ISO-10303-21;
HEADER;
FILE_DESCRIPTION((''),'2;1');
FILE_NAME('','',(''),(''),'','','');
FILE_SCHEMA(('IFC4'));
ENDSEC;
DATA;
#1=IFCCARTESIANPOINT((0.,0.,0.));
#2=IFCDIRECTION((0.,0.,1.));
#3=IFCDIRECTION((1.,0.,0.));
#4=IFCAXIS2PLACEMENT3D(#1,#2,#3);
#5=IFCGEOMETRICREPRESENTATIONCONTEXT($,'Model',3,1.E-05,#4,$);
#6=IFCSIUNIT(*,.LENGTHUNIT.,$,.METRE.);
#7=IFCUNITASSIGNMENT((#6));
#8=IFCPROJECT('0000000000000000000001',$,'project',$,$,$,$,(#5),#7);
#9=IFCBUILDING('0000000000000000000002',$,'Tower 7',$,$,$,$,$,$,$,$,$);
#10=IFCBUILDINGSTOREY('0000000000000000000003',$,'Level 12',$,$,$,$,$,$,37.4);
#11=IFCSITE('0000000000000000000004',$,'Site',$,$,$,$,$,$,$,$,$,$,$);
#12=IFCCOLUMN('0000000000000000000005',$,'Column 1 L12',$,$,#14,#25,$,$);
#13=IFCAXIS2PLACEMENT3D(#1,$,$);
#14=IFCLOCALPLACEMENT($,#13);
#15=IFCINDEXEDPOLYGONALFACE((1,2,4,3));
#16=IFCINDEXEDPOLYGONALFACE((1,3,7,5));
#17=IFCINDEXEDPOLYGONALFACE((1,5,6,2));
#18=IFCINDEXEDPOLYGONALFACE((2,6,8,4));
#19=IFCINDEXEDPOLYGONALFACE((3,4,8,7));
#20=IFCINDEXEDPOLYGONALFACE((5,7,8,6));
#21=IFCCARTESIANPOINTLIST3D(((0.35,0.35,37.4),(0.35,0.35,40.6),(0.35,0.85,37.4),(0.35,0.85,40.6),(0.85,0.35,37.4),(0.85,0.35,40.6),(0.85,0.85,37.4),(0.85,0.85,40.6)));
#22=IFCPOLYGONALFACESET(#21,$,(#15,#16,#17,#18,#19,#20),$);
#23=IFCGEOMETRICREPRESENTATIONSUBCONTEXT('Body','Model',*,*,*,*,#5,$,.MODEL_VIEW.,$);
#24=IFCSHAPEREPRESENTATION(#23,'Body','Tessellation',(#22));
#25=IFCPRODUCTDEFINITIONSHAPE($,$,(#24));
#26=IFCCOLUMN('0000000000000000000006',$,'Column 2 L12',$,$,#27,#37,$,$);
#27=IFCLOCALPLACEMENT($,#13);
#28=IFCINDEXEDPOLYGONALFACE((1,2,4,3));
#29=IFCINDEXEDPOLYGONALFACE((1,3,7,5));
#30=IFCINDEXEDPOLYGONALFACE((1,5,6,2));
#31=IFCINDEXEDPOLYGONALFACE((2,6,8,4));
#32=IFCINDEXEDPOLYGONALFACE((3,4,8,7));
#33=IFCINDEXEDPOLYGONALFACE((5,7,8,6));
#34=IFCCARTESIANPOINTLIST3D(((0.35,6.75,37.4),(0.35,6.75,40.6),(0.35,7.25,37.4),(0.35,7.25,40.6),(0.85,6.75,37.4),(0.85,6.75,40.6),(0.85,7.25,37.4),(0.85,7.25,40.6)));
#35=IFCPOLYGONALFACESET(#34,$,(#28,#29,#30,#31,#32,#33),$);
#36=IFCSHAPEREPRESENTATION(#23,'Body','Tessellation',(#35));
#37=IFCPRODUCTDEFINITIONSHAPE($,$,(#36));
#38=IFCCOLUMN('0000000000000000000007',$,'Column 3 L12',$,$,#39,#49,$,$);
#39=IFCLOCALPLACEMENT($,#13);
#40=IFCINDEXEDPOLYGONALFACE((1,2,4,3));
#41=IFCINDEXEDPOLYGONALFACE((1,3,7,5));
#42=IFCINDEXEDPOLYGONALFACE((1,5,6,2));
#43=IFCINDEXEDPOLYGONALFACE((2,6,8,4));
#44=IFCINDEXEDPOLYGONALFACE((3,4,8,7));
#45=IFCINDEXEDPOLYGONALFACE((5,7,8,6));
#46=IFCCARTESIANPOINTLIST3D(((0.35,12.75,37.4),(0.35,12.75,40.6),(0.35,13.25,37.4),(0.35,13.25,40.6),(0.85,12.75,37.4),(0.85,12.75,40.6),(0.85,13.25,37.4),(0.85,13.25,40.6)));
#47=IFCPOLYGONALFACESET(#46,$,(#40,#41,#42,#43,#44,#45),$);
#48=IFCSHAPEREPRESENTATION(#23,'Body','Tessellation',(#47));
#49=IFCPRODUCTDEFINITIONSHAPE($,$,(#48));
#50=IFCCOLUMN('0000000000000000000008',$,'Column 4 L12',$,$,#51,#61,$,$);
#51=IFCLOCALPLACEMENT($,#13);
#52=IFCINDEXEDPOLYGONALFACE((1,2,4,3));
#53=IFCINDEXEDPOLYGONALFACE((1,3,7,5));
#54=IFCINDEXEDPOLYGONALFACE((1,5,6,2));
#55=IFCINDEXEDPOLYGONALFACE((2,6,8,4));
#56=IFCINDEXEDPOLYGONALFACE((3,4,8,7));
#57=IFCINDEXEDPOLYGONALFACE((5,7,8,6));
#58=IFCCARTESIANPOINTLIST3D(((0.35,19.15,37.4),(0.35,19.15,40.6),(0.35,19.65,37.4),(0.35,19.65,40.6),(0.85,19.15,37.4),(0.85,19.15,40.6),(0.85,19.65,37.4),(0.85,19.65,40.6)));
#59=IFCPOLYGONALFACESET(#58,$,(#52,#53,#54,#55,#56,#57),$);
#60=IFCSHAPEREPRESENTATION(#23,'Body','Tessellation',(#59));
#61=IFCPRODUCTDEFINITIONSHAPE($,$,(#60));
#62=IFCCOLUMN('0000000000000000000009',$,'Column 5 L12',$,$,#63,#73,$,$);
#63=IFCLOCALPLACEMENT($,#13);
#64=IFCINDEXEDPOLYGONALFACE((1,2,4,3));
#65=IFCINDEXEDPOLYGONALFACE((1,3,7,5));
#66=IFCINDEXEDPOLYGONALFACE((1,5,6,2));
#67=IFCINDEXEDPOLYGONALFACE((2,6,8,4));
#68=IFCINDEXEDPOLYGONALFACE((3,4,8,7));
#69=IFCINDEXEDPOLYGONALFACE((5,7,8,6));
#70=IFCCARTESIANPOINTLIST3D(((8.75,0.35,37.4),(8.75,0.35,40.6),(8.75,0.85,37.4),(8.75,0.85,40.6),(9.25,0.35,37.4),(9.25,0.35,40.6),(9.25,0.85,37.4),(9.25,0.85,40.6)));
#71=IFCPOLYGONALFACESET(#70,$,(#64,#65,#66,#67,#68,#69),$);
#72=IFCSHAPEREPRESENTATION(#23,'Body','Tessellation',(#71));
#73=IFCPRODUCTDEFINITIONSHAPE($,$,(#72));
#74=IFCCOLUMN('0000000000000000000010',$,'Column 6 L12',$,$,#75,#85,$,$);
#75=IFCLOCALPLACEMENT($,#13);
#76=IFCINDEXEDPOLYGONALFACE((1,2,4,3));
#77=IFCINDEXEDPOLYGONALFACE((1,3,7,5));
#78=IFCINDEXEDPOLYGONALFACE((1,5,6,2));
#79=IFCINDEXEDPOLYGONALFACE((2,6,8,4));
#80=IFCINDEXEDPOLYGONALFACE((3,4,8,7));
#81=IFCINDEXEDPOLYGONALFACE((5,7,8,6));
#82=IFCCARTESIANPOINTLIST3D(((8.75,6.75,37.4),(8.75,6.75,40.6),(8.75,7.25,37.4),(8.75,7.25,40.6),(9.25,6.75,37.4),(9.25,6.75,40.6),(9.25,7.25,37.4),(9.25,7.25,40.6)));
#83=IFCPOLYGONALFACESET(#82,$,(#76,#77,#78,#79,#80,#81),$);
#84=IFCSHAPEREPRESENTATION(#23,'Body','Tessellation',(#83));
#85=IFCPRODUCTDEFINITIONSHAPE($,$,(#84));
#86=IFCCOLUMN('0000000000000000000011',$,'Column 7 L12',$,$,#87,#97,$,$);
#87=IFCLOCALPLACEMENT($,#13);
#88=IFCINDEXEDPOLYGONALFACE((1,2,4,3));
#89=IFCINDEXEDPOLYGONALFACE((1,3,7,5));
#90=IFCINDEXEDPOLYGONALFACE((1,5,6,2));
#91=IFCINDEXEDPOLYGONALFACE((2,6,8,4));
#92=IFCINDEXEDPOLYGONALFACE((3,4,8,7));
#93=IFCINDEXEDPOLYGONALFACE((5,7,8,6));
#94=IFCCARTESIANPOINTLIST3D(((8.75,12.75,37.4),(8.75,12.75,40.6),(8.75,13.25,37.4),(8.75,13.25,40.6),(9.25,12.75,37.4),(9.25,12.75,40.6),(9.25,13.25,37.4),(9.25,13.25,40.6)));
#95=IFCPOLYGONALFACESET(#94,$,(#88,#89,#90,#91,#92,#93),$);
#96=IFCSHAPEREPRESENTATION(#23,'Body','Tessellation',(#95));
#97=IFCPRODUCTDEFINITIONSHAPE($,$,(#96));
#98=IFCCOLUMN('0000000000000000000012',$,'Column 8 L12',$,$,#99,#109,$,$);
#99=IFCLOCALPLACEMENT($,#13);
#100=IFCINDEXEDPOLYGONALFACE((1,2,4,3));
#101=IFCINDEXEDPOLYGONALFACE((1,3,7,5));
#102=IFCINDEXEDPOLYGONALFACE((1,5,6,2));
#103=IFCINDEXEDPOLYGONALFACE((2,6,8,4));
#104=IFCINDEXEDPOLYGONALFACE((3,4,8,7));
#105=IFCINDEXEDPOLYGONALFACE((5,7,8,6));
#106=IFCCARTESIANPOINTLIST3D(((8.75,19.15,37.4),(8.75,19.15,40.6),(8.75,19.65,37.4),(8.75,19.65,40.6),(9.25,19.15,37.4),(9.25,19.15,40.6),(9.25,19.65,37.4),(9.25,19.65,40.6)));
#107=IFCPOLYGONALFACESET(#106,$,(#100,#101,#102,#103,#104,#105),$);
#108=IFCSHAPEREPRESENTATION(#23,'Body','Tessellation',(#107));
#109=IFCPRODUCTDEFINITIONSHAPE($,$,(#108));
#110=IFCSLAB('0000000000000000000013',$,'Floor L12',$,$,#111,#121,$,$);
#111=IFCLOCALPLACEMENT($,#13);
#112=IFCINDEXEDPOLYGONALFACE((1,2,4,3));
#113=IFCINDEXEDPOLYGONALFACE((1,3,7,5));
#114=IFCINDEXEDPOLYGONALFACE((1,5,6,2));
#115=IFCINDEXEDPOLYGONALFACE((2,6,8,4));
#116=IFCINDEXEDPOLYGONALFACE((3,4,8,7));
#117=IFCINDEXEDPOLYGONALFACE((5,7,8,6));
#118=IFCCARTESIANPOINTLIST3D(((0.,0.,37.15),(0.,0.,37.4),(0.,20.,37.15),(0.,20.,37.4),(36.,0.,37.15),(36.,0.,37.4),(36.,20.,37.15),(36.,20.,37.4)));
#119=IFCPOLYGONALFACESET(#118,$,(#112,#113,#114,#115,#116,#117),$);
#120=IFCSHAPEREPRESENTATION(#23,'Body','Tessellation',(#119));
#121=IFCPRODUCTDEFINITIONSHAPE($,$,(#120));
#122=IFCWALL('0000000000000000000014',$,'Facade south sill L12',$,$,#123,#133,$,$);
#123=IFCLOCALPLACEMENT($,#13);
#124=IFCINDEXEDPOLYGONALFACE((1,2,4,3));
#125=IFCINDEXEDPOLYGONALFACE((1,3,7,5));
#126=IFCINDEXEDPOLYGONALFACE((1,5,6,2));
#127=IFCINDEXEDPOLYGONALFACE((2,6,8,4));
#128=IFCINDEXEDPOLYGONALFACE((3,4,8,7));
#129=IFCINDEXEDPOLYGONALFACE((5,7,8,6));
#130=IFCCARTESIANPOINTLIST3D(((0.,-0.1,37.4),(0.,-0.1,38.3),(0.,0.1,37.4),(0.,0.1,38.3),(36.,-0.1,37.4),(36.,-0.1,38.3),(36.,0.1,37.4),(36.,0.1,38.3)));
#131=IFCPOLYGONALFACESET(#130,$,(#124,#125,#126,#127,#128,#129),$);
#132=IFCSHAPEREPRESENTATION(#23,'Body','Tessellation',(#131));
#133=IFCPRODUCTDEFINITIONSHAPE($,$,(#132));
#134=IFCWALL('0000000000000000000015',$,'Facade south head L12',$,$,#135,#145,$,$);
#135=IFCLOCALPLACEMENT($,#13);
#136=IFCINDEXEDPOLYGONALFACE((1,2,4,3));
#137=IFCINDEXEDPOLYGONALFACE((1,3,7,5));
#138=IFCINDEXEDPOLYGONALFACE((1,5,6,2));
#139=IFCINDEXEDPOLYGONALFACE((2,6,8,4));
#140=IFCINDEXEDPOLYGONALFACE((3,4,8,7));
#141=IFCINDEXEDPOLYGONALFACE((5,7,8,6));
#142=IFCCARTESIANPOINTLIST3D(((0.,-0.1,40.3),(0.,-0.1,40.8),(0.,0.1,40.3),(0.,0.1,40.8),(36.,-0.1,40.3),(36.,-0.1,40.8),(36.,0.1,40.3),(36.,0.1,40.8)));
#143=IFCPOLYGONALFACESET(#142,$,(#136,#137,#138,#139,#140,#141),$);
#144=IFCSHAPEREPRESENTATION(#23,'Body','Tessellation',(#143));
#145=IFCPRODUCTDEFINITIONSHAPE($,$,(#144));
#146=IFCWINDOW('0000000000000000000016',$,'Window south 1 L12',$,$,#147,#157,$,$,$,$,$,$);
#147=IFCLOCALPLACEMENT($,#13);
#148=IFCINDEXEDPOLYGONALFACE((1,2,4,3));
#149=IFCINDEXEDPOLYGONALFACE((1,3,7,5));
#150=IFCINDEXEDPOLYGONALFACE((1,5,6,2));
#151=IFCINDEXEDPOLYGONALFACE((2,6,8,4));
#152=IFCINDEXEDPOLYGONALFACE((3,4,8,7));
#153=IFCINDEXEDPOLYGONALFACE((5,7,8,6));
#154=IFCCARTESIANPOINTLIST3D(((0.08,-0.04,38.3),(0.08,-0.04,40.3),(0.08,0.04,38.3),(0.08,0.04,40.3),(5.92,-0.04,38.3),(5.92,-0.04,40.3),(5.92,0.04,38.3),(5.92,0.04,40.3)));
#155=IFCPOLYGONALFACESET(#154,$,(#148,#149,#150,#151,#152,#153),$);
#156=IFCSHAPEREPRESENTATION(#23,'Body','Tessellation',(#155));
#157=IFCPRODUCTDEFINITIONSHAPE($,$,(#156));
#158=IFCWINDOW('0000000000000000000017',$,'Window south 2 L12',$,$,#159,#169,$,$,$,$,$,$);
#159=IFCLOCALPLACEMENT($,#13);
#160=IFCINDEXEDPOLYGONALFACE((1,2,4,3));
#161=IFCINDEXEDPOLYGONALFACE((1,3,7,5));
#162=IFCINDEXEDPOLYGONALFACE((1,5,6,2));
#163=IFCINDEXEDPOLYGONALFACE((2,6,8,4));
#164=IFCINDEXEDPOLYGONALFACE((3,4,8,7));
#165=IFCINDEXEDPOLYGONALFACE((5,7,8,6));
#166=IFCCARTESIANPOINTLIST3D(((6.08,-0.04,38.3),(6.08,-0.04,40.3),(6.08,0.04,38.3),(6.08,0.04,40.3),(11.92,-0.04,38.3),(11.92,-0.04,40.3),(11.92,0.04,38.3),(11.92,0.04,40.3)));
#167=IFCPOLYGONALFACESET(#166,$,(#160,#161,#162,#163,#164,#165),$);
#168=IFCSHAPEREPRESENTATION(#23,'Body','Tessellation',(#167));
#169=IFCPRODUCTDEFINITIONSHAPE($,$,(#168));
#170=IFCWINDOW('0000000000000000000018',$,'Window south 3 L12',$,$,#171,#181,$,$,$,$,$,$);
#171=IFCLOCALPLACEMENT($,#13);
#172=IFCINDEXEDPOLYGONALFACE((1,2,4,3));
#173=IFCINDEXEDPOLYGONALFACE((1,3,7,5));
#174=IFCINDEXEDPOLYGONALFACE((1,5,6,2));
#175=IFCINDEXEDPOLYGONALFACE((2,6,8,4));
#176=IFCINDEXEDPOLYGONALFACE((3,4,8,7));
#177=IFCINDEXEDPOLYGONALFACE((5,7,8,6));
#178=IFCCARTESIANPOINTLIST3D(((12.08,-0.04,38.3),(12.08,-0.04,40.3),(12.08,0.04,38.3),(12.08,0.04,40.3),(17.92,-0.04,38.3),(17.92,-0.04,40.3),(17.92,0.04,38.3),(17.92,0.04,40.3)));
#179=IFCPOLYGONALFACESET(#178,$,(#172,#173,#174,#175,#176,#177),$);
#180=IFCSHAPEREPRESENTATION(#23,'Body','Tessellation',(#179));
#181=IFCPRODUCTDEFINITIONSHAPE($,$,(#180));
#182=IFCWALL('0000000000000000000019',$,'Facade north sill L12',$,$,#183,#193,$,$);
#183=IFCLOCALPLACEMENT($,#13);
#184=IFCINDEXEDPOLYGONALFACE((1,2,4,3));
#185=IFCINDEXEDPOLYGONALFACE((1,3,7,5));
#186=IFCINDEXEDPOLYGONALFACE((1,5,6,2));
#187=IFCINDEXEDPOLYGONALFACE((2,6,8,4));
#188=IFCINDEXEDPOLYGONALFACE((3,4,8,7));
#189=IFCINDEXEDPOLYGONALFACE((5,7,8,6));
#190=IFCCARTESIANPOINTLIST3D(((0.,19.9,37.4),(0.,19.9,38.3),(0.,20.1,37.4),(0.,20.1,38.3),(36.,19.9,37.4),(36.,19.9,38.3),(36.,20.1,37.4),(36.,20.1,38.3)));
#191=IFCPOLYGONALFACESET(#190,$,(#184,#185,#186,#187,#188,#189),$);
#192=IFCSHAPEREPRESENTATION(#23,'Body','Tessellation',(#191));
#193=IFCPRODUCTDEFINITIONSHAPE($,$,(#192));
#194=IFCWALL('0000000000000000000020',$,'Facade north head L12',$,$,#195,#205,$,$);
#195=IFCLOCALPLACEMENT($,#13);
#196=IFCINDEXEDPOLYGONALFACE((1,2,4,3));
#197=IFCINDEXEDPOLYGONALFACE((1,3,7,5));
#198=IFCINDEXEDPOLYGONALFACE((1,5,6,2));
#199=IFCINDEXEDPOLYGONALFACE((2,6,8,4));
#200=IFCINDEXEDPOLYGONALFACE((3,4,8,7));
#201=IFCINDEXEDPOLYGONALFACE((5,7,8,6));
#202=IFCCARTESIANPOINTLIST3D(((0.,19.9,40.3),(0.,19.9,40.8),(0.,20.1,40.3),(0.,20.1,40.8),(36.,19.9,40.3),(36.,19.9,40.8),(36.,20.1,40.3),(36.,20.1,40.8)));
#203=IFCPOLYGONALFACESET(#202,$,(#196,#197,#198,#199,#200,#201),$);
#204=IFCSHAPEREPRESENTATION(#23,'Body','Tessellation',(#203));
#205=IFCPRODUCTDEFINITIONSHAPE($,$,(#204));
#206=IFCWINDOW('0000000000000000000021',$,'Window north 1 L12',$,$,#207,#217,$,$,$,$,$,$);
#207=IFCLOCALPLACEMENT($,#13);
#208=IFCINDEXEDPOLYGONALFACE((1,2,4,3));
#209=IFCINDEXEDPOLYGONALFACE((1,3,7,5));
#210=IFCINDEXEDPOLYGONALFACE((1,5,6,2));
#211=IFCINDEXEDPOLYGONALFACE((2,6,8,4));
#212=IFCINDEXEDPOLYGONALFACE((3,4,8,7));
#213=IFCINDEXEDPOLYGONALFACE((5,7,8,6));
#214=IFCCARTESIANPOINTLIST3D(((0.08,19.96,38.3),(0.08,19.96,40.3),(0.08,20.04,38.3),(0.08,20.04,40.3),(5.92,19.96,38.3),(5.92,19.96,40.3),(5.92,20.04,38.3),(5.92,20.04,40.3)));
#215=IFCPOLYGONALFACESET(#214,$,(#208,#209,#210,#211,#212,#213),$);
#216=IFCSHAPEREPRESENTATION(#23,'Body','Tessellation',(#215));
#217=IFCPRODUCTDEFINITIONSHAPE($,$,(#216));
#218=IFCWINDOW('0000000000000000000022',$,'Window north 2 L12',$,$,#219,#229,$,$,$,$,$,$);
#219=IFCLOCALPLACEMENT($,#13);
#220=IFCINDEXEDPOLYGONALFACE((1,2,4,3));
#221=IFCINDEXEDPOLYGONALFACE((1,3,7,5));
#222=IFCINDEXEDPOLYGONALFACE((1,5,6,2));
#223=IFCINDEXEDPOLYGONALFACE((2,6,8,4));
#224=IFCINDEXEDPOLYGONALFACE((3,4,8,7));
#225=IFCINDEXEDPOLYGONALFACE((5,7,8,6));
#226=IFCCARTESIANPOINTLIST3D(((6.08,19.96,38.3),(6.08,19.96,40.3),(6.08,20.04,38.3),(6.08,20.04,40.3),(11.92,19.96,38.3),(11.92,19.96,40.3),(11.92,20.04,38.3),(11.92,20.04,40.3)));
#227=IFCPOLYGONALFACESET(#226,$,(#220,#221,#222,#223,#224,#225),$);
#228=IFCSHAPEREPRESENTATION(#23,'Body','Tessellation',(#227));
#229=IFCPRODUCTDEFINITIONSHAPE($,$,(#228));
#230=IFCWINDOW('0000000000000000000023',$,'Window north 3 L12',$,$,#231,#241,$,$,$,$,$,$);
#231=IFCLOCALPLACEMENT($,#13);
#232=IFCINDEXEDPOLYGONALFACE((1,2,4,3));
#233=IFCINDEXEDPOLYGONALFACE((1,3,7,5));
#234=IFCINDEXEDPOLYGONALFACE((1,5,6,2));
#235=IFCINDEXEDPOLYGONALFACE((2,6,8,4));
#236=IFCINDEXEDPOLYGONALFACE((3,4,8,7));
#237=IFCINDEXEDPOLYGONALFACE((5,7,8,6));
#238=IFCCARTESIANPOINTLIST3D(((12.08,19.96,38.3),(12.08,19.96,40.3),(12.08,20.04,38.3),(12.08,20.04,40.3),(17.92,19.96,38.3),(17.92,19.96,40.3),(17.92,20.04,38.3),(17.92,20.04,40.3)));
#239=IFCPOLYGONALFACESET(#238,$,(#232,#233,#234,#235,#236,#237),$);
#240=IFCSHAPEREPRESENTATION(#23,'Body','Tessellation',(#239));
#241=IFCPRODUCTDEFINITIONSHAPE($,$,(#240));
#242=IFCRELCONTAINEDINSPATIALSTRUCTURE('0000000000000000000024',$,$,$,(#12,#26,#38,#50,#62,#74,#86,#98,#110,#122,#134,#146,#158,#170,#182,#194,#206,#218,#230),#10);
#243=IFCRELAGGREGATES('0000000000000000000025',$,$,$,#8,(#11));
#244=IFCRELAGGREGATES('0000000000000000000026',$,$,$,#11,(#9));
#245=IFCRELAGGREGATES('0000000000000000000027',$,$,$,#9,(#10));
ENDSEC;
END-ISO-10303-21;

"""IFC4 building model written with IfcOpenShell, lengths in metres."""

from ifc_helpers import new_model, si_unit, frame, origin, origin_with_axes, origin_2d, place, context, subcontext, project, spatial, rectangle, extrude, element, save


model = new_model("IFC4")

# Units and contexts
model_context = context("Model", 3, precision=1e-05, world=origin_with_axes())
body_context = subcontext(model_context, "Body", "Model", "MODEL_VIEW")
ifc_project = project(units=[si_unit("LENGTHUNIT", "METRE")], contexts=[model_context])

# Site, building, storey
site = spatial("IfcSite", under=ifc_project, Name="Site")
building = spatial("IfcBuilding", under=site, Name="Tower 7")
storey = spatial("IfcBuildingStorey", under=building, Name="Level 12", Elevation=37.4)

# Columns
for number, where, z_axis, x_axis, name in (
    (1, (0.6, 0.6, 37.4), (0.0, 0.0, 1.0), (1.0, 0.0, 0.0), "Column 1 L12"),
    (2, (0.6, 7.0, 37.4), (0.0, 0.0, 1.0), (1.0, 0.0, 0.0), "Column 2 L12"),
    (3, (0.6, 13.0, 37.4), (0.0, 0.0, 1.0), (1.0, 0.0, 0.0), "Column 3 L12"),
    (4, (0.6, 19.4, 37.4), (0.0, 0.0, 1.0), (1.0, 0.0, 0.0), "Column 4 L12"),
    (5, (9.0, 0.6, 37.4), (0.0, 0.0, 1.0), (1.0, 0.0, 0.0), "Column 5 L12"),
    (6, (9.0, 7.0, 37.4), (0.0, 0.0, 1.0), (1.0, 0.0, 0.0), "Column 6 L12"),
    (7, (9.0, 13.0, 37.4), (0.0, 0.0, 1.0), (1.0, 0.0, 0.0), "Column 7 L12"),
    (8, (9.0, 19.4, 37.4), (0.0, 0.0, 1.0), (1.0, 0.0, 0.0), "Column 8 L12"),
):
    element("IfcColumn", number, at=place(None, frame(where, z_axis=z_axis, x_axis=x_axis)), inside=storey, Name=name, context=body_context, shape_type="SweptSolid", body=[
        extrude(rectangle(XDim=0.5, YDim=0.5, at=origin_2d()), origin(), (0.0, 0.0, 1.0), 3.2),
    ])

# Slab
slab_placement = place(None, frame((18.0, 10.0, 37.15), z_axis=(0.0, 0.0, 1.0), x_axis=(1.0, 0.0, 0.0)))
element("IfcSlab", 9, at=slab_placement, inside=storey, Name="Floor L12", context=body_context, shape_type="SweptSolid", body=[
    extrude(rectangle(XDim=36.0, YDim=20.0, at=origin_2d()), origin(), (0.0, 0.0, 1.0), 0.25),
])

# Walls
wall_1_placement = place(None, frame((18.0, 0.0, 37.4), z_axis=(0.0, 0.0, 1.0), x_axis=(1.0, 0.0, 0.0)))
element("IfcWall", 10, at=wall_1_placement, inside=storey, Name="Facade south sill L12", context=body_context, shape_type="SweptSolid", body=[
    extrude(rectangle(XDim=36.0, YDim=0.2, at=origin_2d()), origin(), (0.0, 0.0, 1.0), 0.9),
])
wall_2_placement = place(None, frame((18.0, 0.0, 40.3), z_axis=(0.0, 0.0, 1.0), x_axis=(1.0, 0.0, 0.0)))
element("IfcWall", 11, at=wall_2_placement, inside=storey, Name="Facade south head L12", context=body_context, shape_type="SweptSolid", body=[
    extrude(rectangle(XDim=36.0, YDim=0.2, at=origin_2d()), origin(), (0.0, 0.0, 1.0), 0.5),
])

# Windows
for number, where, z_axis, x_axis, name in (
    (12, (3.0, 0.0, 38.3), (0.0, 0.0, 1.0), (1.0, 0.0, 0.0), "Window south 1 L12"),
    (13, (9.0, 0.0, 38.3), (0.0, 0.0, 1.0), (1.0, 0.0, 0.0), "Window south 2 L12"),
):
    element("IfcWindow", number, at=place(None, frame(where, z_axis=z_axis, x_axis=x_axis)), inside=storey, Name=name, context=body_context, shape_type="SweptSolid", body=[
        extrude(rectangle(XDim=5.84, YDim=0.08, at=origin_2d()), origin(), (0.0, 0.0, 1.0), 2.0),
    ])
window_1_placement = place(None, frame((15.0, 0.0, 38.3), z_axis=(0.0, 0.0, 1.0), x_axis=(1.0, 0.0, 0.0)))
element("IfcWindow", 14, at=window_1_placement, inside=storey, Name="Window south 3 L12", context=body_context, shape_type="SweptSolid", body=[
    extrude(rectangle(XDim=5.84, YDim=0.08, at=origin_2d()), origin(), (0.0, 0.0, 1.0), 2.0),
])

# Walls
wall_3_placement = place(None, frame((18.0, 20.0, 37.4), z_axis=(0.0, 0.0, 1.0), x_axis=(1.0, 0.0, 0.0)))
element("IfcWall", 15, at=wall_3_placement, inside=storey, Name="Facade north sill L12", context=body_context, shape_type="SweptSolid", body=[
    extrude(rectangle(XDim=36.0, YDim=0.2, at=origin_2d()), origin(), (0.0, 0.0, 1.0), 0.9),
])
wall_4_placement = place(None, frame((18.0, 20.0, 40.3), z_axis=(0.0, 0.0, 1.0), x_axis=(1.0, 0.0, 0.0)))
element("IfcWall", 16, at=wall_4_placement, inside=storey, Name="Facade north head L12", context=body_context, shape_type="SweptSolid", body=[
    extrude(rectangle(XDim=36.0, YDim=0.2, at=origin_2d()), origin(), (0.0, 0.0, 1.0), 0.5),
])

# Windows
for number, where, z_axis, x_axis, name in (
    (17, (3.0, 20.0, 38.3), (0.0, 0.0, 1.0), (1.0, 0.0, 0.0), "Window north 1 L12"),
    (18, (9.0, 20.0, 38.3), (0.0, 0.0, 1.0), (1.0, 0.0, 0.0), "Window north 2 L12"),
):
    element("IfcWindow", number, at=place(None, frame(where, z_axis=z_axis, x_axis=x_axis)), inside=storey, Name=name, context=body_context, shape_type="SweptSolid", body=[
        extrude(rectangle(XDim=5.84, YDim=0.08, at=origin_2d()), origin(), (0.0, 0.0, 1.0), 2.0),
    ])
window_2_placement = place(None, frame((15.0, 20.0, 38.3), z_axis=(0.0, 0.0, 1.0), x_axis=(1.0, 0.0, 0.0)))
element("IfcWindow", 19, at=window_2_placement, inside=storey, Name="Window north 3 L12", context=body_context, shape_type="SweptSolid", body=[
    extrude(rectangle(XDim=5.84, YDim=0.08, at=origin_2d()), origin(), (0.0, 0.0, 1.0), 2.0),
])

save(model, "model.ifc")
